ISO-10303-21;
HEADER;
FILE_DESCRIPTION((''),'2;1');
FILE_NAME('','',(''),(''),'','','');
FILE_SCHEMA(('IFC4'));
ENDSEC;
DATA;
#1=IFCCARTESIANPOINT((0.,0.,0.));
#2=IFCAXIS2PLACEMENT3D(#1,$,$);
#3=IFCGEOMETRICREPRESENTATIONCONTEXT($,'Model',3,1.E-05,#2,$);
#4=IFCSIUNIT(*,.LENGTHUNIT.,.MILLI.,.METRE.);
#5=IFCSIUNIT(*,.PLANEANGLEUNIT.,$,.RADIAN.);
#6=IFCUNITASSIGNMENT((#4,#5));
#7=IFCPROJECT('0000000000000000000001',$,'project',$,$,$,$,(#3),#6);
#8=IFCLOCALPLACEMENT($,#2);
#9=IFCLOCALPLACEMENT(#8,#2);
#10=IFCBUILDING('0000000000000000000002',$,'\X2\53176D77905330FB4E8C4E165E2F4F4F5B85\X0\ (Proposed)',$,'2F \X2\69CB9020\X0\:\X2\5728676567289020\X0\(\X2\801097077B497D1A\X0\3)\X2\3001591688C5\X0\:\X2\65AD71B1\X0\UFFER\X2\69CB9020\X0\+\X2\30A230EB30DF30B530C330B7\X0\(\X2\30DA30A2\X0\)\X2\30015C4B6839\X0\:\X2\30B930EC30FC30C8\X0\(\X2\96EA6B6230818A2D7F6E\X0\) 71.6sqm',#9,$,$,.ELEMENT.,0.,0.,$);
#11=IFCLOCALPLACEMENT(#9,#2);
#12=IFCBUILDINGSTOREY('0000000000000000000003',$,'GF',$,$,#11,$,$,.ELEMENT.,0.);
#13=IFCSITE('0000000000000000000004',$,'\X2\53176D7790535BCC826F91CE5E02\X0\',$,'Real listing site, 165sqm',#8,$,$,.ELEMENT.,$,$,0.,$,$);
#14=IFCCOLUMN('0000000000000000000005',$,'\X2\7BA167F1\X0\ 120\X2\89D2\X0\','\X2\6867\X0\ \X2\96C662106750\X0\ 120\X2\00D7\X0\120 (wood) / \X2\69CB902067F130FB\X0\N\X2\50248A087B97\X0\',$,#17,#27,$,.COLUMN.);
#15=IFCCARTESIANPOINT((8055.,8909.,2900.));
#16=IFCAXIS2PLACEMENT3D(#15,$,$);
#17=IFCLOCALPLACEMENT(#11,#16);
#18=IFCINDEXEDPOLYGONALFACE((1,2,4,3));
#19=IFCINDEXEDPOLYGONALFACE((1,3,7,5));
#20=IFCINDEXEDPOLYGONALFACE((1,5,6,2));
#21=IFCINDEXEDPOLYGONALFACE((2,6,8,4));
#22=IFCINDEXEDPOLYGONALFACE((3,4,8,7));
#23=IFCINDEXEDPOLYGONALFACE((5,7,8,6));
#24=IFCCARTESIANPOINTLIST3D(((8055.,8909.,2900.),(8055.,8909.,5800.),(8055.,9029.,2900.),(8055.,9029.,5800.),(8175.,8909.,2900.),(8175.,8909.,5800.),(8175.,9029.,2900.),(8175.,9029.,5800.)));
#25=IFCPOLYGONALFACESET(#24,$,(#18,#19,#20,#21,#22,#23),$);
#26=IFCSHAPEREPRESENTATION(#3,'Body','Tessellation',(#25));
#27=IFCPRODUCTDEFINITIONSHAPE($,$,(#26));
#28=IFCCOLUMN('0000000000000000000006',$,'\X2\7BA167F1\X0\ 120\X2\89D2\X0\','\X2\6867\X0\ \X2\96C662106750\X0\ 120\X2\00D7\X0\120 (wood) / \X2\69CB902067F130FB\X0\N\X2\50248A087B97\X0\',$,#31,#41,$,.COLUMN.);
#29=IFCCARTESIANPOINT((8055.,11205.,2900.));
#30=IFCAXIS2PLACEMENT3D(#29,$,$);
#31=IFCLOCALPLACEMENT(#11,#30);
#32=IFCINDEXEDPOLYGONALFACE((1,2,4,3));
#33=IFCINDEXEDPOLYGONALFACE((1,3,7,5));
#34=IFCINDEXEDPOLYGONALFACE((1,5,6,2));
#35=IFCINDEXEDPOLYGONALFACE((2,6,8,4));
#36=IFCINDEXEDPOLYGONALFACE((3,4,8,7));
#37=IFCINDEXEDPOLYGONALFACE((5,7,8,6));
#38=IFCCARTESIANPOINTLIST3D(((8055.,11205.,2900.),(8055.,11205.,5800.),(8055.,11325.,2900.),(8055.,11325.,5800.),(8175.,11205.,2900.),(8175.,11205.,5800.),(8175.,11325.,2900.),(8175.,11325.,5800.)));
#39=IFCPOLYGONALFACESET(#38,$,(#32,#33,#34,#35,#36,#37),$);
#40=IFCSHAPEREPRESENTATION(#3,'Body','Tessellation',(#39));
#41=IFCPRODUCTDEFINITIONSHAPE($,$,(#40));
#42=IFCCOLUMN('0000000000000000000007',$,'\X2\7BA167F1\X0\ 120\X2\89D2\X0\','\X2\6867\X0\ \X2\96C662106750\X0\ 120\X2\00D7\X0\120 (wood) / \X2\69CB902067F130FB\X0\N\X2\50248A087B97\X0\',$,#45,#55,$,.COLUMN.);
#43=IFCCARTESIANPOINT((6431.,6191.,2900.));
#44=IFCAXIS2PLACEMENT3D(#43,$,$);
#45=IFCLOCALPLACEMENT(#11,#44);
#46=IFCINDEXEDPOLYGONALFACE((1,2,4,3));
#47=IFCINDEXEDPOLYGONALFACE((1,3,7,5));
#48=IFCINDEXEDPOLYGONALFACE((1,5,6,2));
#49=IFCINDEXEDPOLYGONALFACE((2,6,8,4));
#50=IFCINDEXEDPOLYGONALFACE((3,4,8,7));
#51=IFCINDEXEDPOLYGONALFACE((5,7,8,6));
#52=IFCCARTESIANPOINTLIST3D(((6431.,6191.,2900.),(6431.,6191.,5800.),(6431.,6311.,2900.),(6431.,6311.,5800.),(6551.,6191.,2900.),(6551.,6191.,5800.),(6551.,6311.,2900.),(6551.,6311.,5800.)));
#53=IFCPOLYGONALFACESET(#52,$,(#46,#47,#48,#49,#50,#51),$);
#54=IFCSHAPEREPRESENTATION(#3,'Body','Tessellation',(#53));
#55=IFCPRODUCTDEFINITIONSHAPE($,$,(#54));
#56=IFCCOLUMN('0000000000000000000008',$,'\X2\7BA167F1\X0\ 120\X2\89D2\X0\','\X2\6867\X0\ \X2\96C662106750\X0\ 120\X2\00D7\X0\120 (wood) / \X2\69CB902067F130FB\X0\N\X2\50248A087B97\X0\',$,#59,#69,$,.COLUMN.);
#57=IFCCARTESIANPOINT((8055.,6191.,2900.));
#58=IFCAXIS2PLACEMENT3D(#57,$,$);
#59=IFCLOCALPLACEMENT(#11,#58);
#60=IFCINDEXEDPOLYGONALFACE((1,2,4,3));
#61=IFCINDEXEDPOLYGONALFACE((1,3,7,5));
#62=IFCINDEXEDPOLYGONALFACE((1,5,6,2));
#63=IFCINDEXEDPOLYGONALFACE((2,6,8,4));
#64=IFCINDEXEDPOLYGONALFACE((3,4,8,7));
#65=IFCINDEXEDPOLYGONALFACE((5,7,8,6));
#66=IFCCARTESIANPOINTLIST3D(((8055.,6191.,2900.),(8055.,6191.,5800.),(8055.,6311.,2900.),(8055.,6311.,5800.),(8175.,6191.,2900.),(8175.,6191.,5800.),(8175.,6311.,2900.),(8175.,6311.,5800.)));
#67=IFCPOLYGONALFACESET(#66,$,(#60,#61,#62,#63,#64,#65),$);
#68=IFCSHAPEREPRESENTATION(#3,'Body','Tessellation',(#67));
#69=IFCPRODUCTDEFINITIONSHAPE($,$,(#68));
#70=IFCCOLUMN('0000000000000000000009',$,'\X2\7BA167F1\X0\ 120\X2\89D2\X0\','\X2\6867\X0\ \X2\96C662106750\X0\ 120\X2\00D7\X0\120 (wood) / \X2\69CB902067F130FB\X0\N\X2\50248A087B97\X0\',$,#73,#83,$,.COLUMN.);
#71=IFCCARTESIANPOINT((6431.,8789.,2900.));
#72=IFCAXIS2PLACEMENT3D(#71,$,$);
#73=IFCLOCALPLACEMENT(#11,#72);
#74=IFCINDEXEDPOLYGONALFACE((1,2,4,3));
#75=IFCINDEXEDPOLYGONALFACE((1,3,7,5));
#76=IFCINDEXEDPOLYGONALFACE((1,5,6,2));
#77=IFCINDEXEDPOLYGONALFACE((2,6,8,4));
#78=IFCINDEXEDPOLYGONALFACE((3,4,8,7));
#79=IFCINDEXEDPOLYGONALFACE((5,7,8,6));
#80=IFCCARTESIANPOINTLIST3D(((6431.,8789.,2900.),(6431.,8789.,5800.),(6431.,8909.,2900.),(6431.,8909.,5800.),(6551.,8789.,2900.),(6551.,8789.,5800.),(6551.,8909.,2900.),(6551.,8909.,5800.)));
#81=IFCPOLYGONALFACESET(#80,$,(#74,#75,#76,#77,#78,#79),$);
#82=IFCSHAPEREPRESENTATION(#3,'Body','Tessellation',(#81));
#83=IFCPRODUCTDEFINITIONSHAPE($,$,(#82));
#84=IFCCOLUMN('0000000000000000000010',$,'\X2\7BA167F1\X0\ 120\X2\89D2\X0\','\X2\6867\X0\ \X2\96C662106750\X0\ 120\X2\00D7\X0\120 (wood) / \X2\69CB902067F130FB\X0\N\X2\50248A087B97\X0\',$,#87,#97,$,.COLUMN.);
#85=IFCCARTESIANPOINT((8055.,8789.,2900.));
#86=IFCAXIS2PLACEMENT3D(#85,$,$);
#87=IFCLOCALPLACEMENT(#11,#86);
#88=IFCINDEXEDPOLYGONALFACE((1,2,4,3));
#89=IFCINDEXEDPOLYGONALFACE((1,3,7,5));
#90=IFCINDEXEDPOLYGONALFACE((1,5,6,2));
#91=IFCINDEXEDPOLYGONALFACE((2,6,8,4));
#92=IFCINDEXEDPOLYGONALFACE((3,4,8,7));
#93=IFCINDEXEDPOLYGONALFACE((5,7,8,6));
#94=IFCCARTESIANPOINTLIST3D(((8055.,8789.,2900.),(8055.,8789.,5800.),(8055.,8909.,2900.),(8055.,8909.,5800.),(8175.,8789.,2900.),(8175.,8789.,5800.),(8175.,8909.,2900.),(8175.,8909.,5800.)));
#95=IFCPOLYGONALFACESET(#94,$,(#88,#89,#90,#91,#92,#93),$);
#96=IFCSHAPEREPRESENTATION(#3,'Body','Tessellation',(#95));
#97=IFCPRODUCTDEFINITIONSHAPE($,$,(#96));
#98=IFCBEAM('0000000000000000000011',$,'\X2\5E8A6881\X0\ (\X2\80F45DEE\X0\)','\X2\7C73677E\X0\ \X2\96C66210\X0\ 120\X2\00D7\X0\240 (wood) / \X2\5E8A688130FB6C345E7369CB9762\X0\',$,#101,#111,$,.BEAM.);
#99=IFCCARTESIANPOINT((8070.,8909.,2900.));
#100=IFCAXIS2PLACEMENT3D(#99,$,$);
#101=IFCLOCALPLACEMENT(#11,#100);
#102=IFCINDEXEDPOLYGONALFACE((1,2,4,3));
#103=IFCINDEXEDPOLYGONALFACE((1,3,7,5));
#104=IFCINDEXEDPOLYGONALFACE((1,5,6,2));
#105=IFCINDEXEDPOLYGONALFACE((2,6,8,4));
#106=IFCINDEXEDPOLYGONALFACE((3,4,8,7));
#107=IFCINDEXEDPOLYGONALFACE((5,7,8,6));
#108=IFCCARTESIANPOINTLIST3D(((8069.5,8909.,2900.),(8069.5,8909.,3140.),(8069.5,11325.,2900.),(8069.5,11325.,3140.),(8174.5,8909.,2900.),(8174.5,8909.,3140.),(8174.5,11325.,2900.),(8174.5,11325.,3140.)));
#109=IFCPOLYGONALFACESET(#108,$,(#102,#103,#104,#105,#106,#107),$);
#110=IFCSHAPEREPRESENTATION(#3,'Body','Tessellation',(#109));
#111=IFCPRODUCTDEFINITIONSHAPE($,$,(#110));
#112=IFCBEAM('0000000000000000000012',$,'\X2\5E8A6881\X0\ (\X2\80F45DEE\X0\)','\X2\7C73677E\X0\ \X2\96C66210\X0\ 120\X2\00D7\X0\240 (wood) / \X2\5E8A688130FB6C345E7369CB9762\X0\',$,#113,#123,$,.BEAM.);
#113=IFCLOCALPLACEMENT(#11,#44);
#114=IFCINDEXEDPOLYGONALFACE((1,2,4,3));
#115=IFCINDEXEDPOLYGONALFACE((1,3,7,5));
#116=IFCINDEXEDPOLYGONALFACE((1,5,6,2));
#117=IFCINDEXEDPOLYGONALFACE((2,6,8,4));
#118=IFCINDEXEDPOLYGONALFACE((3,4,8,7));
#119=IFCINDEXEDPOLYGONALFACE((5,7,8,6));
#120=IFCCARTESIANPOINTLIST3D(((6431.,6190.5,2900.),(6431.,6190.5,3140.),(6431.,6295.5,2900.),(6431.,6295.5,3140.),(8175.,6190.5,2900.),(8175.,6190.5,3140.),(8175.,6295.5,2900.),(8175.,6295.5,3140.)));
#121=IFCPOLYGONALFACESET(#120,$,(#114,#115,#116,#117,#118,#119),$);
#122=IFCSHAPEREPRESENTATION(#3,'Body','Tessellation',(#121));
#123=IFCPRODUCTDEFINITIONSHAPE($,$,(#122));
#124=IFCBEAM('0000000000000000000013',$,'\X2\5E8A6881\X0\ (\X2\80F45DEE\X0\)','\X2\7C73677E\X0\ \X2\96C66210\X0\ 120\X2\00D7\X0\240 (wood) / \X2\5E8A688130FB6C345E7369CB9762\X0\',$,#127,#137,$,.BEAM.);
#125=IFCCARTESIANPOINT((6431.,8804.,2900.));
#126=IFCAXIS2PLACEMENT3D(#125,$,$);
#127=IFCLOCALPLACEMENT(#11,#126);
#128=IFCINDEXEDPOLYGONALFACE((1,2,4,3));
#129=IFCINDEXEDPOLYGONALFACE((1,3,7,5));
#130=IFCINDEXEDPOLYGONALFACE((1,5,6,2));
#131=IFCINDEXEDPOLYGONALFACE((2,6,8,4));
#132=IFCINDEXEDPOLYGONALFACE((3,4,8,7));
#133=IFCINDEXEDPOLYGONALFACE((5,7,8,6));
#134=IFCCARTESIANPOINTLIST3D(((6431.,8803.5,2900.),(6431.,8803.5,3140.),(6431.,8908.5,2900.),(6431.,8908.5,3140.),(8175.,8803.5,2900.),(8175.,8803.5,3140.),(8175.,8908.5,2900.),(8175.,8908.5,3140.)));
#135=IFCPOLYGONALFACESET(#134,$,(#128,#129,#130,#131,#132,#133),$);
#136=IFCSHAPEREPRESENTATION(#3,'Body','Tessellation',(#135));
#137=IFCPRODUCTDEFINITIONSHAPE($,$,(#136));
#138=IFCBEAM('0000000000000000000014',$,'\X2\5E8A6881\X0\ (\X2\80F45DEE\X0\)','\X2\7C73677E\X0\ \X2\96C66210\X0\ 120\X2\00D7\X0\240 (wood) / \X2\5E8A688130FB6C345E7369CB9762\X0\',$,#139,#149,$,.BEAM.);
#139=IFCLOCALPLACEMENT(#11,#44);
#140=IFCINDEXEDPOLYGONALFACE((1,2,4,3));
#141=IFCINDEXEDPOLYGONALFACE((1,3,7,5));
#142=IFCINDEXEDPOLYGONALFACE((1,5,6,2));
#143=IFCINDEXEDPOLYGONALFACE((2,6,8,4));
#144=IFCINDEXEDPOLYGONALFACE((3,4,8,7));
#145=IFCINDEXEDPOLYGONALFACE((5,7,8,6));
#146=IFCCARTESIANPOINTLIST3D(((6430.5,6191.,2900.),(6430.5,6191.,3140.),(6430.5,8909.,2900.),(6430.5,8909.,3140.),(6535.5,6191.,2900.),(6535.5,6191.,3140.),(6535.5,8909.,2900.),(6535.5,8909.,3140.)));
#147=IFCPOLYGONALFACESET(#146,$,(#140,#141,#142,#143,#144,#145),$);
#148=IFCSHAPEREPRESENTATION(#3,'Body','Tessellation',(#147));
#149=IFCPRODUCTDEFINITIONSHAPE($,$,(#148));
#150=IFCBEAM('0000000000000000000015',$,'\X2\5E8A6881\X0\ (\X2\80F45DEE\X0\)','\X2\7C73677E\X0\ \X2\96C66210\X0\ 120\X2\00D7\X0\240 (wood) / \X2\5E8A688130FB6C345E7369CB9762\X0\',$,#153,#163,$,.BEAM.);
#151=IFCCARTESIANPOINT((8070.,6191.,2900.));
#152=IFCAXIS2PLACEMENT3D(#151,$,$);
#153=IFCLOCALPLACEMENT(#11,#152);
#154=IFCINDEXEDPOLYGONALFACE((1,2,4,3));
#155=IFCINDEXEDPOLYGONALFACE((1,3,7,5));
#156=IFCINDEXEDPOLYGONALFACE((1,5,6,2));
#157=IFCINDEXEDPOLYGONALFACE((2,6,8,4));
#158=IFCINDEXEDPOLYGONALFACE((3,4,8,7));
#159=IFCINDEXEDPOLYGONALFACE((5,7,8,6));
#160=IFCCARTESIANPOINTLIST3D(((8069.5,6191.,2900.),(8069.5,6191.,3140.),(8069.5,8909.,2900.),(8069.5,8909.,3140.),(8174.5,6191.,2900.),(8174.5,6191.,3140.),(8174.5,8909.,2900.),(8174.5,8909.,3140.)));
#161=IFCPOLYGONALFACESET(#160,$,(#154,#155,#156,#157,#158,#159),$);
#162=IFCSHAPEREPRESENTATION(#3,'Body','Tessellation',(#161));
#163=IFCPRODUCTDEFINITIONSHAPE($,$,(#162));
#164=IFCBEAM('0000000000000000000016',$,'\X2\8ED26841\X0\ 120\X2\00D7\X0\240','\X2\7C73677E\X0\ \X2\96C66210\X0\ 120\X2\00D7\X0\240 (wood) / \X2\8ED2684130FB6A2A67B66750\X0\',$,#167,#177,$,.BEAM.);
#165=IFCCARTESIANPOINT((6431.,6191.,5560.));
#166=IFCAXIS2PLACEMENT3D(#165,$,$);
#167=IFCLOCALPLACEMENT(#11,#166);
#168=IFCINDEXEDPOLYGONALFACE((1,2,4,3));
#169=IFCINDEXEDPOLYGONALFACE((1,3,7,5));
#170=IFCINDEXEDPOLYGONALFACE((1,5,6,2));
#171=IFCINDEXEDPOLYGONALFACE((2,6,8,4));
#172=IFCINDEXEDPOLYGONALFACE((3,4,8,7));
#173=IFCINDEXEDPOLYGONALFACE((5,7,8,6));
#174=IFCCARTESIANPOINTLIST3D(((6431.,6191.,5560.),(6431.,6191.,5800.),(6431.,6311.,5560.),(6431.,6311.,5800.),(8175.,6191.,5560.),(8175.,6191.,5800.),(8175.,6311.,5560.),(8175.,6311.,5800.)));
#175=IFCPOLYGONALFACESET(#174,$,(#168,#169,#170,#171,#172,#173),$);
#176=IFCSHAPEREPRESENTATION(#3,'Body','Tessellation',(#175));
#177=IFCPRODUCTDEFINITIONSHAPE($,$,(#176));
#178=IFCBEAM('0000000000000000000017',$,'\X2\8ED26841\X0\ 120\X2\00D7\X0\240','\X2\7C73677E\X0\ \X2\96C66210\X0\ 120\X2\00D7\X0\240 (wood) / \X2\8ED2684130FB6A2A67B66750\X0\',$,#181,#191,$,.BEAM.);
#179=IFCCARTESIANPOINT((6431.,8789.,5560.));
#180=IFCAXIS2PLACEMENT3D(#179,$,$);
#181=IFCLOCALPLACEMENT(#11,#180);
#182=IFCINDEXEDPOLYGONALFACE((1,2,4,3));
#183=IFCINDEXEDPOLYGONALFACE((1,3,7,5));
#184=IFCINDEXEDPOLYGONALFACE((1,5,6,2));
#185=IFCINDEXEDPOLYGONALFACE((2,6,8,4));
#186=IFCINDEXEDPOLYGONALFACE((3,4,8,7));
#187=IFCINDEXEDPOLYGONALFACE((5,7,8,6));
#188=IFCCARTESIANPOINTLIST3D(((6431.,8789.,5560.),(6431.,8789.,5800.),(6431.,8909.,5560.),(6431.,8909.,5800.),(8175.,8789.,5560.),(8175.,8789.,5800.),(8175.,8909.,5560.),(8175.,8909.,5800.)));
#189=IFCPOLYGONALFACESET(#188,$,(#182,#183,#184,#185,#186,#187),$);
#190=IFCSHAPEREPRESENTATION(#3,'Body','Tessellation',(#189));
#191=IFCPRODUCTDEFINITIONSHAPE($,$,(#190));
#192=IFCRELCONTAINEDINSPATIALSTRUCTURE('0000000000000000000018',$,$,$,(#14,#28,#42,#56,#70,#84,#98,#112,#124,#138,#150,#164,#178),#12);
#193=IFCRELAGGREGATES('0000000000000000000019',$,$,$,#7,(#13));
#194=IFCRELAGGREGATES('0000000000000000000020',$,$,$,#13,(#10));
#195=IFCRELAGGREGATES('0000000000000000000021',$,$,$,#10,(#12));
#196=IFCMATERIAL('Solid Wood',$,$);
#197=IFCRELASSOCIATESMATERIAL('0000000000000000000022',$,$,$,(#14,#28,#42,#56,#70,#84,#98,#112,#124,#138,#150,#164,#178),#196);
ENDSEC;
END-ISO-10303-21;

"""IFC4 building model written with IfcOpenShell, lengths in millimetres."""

from ifc_helpers import new_model, si_unit, frame, frame_2d, origin, place, context, project, spatial, rectangle, extrude, material, element, save


model = new_model("IFC4")

# Units and contexts
model_context = context("Model", 3, precision=1e-05, world=origin())
ifc_project = project(units=[si_unit("LENGTHUNIT", "METRE", prefix="MILLI"), si_unit("PLANEANGLEUNIT", "RADIAN")], contexts=[model_context])

# Site, building, storey
site_placement = place(None, origin())
site = spatial("IfcSite", under=ifc_project, at=site_placement, Name="北海道富良野市", ObjectType="Real listing site, 165sqm", CompositionType="ELEMENT", RefElevation=0.0)
building_placement = place(site_placement, origin())
building = spatial("IfcBuilding", under=site, at=building_placement, Name="北海道・二世帯住宅 (Proposed)", ObjectType="2F 構造:在来木造(耐震等級3)、外装:断熱UFFER構造+アルミサッシ(ペア)、屋根:スレート(雪止め設置) 71.6sqm", CompositionType="ELEMENT", ElevationOfRefHeight=0.0, ElevationOfTerrain=0.0)
storey_placement = place(building_placement, origin())
storey = spatial("IfcBuildingStorey", under=building, at=storey_placement, Name="GF", CompositionType="ELEMENT", Elevation=0.0)

# Columns
ifc_material_1 = material(Name="Solid Wood")
column_1_placement = place(storey_placement, frame((8055.0, 8909.0, 2900.0)))
element("IfcColumn", 1, at=column_1_placement, inside=storey, material=ifc_material_1, Name="管柱 120角", Description="桧 集成材 120×120 (wood) / 構造柱・N値計算", PredefinedType="COLUMN", context=model_context, shape_type="SweptSolid", body=[
    extrude(rectangle(XDim=120.0, YDim=120.0, at=frame_2d((60.0, 60.0))), frame((8055.0, 8909.0, 2900.0)), (0.0, 0.0, 1.0), 2900.0),
])
column_2_placement = place(storey_placement, frame((8055.0, 11205.0, 2900.0)))
element("IfcColumn", 2, at=column_2_placement, inside=storey, material=ifc_material_1, Name="管柱 120角", Description="桧 集成材 120×120 (wood) / 構造柱・N値計算", PredefinedType="COLUMN", context=model_context, shape_type="SweptSolid", body=[
    extrude(rectangle(XDim=120.0, YDim=120.0, at=frame_2d((60.0, 60.0))), frame((8055.0, 11205.0, 2900.0)), (0.0, 0.0, 1.0), 2900.0),
])
column_3_placement = place(storey_placement, frame((6431.0, 6191.0, 2900.0)))
element("IfcColumn", 3, at=column_3_placement, inside=storey, material=ifc_material_1, Name="管柱 120角", Description="桧 集成材 120×120 (wood) / 構造柱・N値計算", PredefinedType="COLUMN", context=model_context, shape_type="SweptSolid", body=[
    extrude(rectangle(XDim=120.0, YDim=120.0, at=frame_2d((60.0, 60.0))), frame((6431.0, 6191.0, 2900.0)), (0.0, 0.0, 1.0), 2900.0),
])
column_4_placement = place(storey_placement, frame((8055.0, 6191.0, 2900.0)))
element("IfcColumn", 4, at=column_4_placement, inside=storey, material=ifc_material_1, Name="管柱 120角", Description="桧 集成材 120×120 (wood) / 構造柱・N値計算", PredefinedType="COLUMN", context=model_context, shape_type="SweptSolid", body=[
    extrude(rectangle(XDim=120.0, YDim=120.0, at=frame_2d((60.0, 60.0))), frame((8055.0, 6191.0, 2900.0)), (0.0, 0.0, 1.0), 2900.0),
])
column_5_placement = place(storey_placement, frame((6431.0, 8789.0, 2900.0)))
element("IfcColumn", 5, at=column_5_placement, inside=storey, material=ifc_material_1, Name="管柱 120角", Description="桧 集成材 120×120 (wood) / 構造柱・N値計算", PredefinedType="COLUMN", context=model_context, shape_type="SweptSolid", body=[
    extrude(rectangle(XDim=120.0, YDim=120.0, at=frame_2d((60.0, 60.0))), frame((6431.0, 8789.0, 2900.0)), (0.0, 0.0, 1.0), 2900.0),
])
column_6_placement = place(storey_placement, frame((8055.0, 8789.0, 2900.0)))
element("IfcColumn", 6, at=column_6_placement, inside=storey, material=ifc_material_1, Name="管柱 120角", Description="桧 集成材 120×120 (wood) / 構造柱・N値計算", PredefinedType="COLUMN", context=model_context, shape_type="SweptSolid", body=[
    extrude(rectangle(XDim=120.0, YDim=120.0, at=frame_2d((60.0, 60.0))), frame((8055.0, 8789.0, 2900.0)), (0.0, 0.0, 1.0), 2900.0),
])

# Beams
beam_1_placement = place(storey_placement, frame((8070.0, 8909.0, 2900.0)))
element("IfcBeam", 7, at=beam_1_placement, inside=storey, material=ifc_material_1, Name="床梁 (胴差)", Description="米松 集成 120×240 (wood) / 床梁・水平構面", PredefinedType="BEAM", context=model_context, shape_type="SweptSolid", body=[
    extrude(rectangle(XDim=105.0, YDim=2416.0, at=frame_2d((52.0, 1208.0))), frame((8070.0, 8909.0, 2900.0)), (0.0, 0.0, 1.0), 240.0),
])
beam_2_placement = place(storey_placement, frame((6431.0, 6191.0, 2900.0)))
element("IfcBeam", 8, at=beam_2_placement, inside=storey, material=ifc_material_1, Name="床梁 (胴差)", Description="米松 集成 120×240 (wood) / 床梁・水平構面", PredefinedType="BEAM", context=model_context, shape_type="SweptSolid", body=[
    extrude(rectangle(XDim=1744.0, YDim=105.0, at=frame_2d((872.0, 52.0))), frame((6431.0, 6191.0, 2900.0)), (0.0, 0.0, 1.0), 240.0),
])
beam_3_placement = place(storey_placement, frame((6431.0, 8804.0, 2900.0)))
element("IfcBeam", 9, at=beam_3_placement, inside=storey, material=ifc_material_1, Name="床梁 (胴差)", Description="米松 集成 120×240 (wood) / 床梁・水平構面", PredefinedType="BEAM", context=model_context, shape_type="SweptSolid", body=[
    extrude(rectangle(XDim=1744.0, YDim=105.0, at=frame_2d((872.0, 52.0))), frame((6431.0, 8804.0, 2900.0)), (0.0, 0.0, 1.0), 240.0),
])
beam_4_placement = place(storey_placement, frame((6431.0, 6191.0, 2900.0)))
element("IfcBeam", 10, at=beam_4_placement, inside=storey, material=ifc_material_1, Name="床梁 (胴差)", Description="米松 集成 120×240 (wood) / 床梁・水平構面", PredefinedType="BEAM", context=model_context, shape_type="SweptSolid", body=[
    extrude(rectangle(XDim=105.0, YDim=2718.0, at=frame_2d((52.0, 1359.0))), frame((6431.0, 6191.0, 2900.0)), (0.0, 0.0, 1.0), 240.0),
])
beam_5_placement = place(storey_placement, frame((8070.0, 6191.0, 2900.0)))
element("IfcBeam", 11, at=beam_5_placement, inside=storey, material=ifc_material_1, Name="床梁 (胴差)", Description="米松 集成 120×240 (wood) / 床梁・水平構面", PredefinedType="BEAM", context=model_context, shape_type="SweptSolid", body=[
    extrude(rectangle(XDim=105.0, YDim=2718.0, at=frame_2d((52.0, 1359.0))), frame((8070.0, 6191.0, 2900.0)), (0.0, 0.0, 1.0), 240.0),
])
beam_6_placement = place(storey_placement, frame((6431.0, 6191.0, 5560.0)))
element("IfcBeam", 12, at=beam_6_placement, inside=storey, material=ifc_material_1, Name="軒桁 120×240", Description="米松 集成 120×240 (wood) / 軒桁・横架材", PredefinedType="BEAM", context=model_context, shape_type="SweptSolid", body=[
    extrude(rectangle(XDim=1744.0, YDim=120.0, at=frame_2d((872.0, 60.0))), frame((6431.0, 6191.0, 5560.0)), (0.0, 0.0, 1.0), 240.0),
])
beam_7_placement = place(storey_placement, frame((6431.0, 8789.0, 5560.0)))
element("IfcBeam", 13, at=beam_7_placement, inside=storey, material=ifc_material_1, Name="軒桁 120×240", Description="米松 集成 120×240 (wood) / 軒桁・横架材", PredefinedType="BEAM", context=model_context, shape_type="SweptSolid", body=[
    extrude(rectangle(XDim=1744.0, YDim=120.0, at=frame_2d((872.0, 60.0))), frame((6431.0, 8789.0, 5560.0)), (0.0, 0.0, 1.0), 240.0),
])

save(model, "model.ifc")
